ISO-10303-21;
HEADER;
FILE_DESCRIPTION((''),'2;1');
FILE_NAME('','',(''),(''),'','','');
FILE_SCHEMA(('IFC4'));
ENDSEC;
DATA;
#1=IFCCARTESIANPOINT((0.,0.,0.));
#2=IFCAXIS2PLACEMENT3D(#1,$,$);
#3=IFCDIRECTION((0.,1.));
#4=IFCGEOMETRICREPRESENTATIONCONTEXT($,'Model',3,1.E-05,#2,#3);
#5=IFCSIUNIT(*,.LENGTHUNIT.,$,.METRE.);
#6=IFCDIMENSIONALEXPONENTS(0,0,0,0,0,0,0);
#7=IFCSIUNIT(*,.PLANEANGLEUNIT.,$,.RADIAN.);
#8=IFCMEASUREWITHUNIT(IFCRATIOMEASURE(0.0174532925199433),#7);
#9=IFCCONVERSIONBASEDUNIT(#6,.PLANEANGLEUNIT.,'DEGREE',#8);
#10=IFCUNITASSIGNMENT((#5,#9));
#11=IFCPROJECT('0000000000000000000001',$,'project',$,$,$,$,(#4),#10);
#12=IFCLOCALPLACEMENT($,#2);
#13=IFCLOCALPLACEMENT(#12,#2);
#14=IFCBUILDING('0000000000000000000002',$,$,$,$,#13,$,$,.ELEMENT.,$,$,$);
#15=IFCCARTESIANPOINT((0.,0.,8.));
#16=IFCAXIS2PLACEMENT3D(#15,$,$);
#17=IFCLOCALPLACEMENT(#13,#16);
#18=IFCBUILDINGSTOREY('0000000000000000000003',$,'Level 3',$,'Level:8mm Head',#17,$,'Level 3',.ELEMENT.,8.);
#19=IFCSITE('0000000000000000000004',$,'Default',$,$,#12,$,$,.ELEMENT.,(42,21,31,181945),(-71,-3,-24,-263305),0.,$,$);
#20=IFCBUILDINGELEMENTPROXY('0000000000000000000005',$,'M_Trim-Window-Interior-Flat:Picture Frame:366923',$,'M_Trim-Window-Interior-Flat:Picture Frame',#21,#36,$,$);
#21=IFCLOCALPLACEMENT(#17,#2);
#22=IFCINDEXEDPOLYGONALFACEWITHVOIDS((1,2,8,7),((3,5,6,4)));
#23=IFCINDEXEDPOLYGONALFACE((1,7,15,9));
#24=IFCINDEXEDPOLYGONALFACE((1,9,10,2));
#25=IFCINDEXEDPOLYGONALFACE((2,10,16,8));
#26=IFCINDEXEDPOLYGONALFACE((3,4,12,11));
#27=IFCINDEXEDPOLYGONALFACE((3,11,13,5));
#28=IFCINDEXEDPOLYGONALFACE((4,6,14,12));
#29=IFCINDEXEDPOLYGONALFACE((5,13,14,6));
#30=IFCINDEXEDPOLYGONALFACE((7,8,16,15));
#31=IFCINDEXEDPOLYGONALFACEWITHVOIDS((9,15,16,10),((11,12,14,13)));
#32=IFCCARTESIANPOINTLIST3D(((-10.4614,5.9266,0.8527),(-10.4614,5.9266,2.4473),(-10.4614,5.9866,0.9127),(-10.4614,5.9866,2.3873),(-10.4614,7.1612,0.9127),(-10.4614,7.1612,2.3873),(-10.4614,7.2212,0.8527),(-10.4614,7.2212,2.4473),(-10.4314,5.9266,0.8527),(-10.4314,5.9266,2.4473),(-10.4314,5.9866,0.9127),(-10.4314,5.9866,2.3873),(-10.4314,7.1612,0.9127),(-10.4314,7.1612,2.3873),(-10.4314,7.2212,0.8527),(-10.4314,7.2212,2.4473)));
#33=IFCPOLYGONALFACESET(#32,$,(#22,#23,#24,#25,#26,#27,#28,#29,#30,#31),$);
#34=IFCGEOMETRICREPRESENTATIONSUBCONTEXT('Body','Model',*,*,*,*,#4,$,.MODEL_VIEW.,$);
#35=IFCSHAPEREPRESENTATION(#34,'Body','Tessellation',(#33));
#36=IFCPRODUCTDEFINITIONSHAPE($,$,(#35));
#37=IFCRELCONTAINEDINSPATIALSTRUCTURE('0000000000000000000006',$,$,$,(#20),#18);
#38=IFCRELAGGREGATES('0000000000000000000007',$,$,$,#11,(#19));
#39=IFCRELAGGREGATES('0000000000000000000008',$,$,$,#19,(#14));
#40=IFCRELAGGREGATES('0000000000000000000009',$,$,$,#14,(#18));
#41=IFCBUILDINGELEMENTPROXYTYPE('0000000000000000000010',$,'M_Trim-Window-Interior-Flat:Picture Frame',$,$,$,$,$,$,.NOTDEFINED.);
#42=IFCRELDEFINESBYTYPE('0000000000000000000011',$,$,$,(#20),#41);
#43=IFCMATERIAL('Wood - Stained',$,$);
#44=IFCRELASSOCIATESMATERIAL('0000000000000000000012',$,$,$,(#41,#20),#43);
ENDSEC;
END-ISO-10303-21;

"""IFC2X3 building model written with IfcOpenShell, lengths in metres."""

from ifc_helpers import new_model, entity, si_unit, converted_unit, direction, frame, origin, place, context, subcontext, project, spatial, polyline, outline, extrude, source, transform, mapped, material, type_object, type_shapes, element, save


model = new_model("IFC2X3")

# Units and contexts
model_context = context("Model", 3, precision=1e-05, world=origin(), true_north=direction((0.0, 1.0)))
body_context = subcontext(model_context, "Body", "Model", "MODEL_VIEW")
ifc_project = project(units=[si_unit("LENGTHUNIT", "METRE"), converted_unit("PLANEANGLEUNIT", "DEGREE", entity("IfcRatioMeasure", 0.0174532925199433), si_unit("PLANEANGLEUNIT", "RADIAN"), dimensions=[0, 0, 0, 0, 0, 0, 0])], contexts=[model_context])

# Site, building, storey
site_placement = place(None, origin())
site = spatial("IfcSite", under=ifc_project, at=site_placement, Name="Default", CompositionType="ELEMENT", RefLatitude=(42, 21, 31, 181945), RefLongitude=(-71, -3, -24, -263305), RefElevation=0.0)
building_placement = place(site_placement, origin())
building = spatial("IfcBuilding", under=site, at=building_placement, CompositionType="ELEMENT")
storey_placement = place(building_placement, frame((0.0, 0.0, 8.0)))
storey = spatial("IfcBuildingStorey", under=building, at=storey_placement, Name="Level 3", ObjectType="Level:8mm Head", LongName="Level 3", CompositionType="ELEMENT", Elevation=8.0)

# Shared definitions
ifc_material_1 = material(Name="Wood - Stained")

# Building element proxy
building_element_proxy_type_1 = type_object("IfcBuildingElementProxyType", Name="M_Trim-Window-Interior-Flat:Picture Frame", PredefinedType="NOTDEFINED", material=ifc_material_1)
shared_shape_1 = source(origin(), body_context, "Body", "SweptSolid", [
    extrude(outline(polyline([(-0.6473, -0.7973), (0.6473, -0.7973), (0.6473, 0.7973), (-0.6473, 0.7973), (-0.6473, -0.7973)]), holes=[polyline([(-0.5873, -0.7373), (-0.5873, 0.7373), (0.5873, 0.7373), (0.5873, -0.7373), (-0.5873, -0.7373)])]), frame((0.0, -0.75, 0.0), z_axis=(0.0, 0.0, 1.0), x_axis=(-1.0, 0.0, 0.0)), (0.0, 0.0, 1.0), 0.03),
])
type_shapes(building_element_proxy_type_1, [shared_shape_1])
for number, where, z_axis, x_axis, name in (
    (1, (-10.4314, 6.5739, 2.4), (-1.0, 0.0, 0.0), (0.0, -1.0, 0.0), "M_Trim-Window-Interior-Flat:Picture Frame:366923"),
):
    element("IfcBuildingElementProxy", number, at=place(storey_placement, frame(where, z_axis=z_axis, x_axis=x_axis)), inside=storey, type_object=building_element_proxy_type_1, material=ifc_material_1, Name=name, ObjectType="M_Trim-Window-Interior-Flat:Picture Frame", context=body_context, shape_type="MappedRepresentation", body=[
        mapped(shared_shape_1, transform((0.0, 0.0, 0.0), scale=1.0)),
    ])

save(model, "model.ifc")
